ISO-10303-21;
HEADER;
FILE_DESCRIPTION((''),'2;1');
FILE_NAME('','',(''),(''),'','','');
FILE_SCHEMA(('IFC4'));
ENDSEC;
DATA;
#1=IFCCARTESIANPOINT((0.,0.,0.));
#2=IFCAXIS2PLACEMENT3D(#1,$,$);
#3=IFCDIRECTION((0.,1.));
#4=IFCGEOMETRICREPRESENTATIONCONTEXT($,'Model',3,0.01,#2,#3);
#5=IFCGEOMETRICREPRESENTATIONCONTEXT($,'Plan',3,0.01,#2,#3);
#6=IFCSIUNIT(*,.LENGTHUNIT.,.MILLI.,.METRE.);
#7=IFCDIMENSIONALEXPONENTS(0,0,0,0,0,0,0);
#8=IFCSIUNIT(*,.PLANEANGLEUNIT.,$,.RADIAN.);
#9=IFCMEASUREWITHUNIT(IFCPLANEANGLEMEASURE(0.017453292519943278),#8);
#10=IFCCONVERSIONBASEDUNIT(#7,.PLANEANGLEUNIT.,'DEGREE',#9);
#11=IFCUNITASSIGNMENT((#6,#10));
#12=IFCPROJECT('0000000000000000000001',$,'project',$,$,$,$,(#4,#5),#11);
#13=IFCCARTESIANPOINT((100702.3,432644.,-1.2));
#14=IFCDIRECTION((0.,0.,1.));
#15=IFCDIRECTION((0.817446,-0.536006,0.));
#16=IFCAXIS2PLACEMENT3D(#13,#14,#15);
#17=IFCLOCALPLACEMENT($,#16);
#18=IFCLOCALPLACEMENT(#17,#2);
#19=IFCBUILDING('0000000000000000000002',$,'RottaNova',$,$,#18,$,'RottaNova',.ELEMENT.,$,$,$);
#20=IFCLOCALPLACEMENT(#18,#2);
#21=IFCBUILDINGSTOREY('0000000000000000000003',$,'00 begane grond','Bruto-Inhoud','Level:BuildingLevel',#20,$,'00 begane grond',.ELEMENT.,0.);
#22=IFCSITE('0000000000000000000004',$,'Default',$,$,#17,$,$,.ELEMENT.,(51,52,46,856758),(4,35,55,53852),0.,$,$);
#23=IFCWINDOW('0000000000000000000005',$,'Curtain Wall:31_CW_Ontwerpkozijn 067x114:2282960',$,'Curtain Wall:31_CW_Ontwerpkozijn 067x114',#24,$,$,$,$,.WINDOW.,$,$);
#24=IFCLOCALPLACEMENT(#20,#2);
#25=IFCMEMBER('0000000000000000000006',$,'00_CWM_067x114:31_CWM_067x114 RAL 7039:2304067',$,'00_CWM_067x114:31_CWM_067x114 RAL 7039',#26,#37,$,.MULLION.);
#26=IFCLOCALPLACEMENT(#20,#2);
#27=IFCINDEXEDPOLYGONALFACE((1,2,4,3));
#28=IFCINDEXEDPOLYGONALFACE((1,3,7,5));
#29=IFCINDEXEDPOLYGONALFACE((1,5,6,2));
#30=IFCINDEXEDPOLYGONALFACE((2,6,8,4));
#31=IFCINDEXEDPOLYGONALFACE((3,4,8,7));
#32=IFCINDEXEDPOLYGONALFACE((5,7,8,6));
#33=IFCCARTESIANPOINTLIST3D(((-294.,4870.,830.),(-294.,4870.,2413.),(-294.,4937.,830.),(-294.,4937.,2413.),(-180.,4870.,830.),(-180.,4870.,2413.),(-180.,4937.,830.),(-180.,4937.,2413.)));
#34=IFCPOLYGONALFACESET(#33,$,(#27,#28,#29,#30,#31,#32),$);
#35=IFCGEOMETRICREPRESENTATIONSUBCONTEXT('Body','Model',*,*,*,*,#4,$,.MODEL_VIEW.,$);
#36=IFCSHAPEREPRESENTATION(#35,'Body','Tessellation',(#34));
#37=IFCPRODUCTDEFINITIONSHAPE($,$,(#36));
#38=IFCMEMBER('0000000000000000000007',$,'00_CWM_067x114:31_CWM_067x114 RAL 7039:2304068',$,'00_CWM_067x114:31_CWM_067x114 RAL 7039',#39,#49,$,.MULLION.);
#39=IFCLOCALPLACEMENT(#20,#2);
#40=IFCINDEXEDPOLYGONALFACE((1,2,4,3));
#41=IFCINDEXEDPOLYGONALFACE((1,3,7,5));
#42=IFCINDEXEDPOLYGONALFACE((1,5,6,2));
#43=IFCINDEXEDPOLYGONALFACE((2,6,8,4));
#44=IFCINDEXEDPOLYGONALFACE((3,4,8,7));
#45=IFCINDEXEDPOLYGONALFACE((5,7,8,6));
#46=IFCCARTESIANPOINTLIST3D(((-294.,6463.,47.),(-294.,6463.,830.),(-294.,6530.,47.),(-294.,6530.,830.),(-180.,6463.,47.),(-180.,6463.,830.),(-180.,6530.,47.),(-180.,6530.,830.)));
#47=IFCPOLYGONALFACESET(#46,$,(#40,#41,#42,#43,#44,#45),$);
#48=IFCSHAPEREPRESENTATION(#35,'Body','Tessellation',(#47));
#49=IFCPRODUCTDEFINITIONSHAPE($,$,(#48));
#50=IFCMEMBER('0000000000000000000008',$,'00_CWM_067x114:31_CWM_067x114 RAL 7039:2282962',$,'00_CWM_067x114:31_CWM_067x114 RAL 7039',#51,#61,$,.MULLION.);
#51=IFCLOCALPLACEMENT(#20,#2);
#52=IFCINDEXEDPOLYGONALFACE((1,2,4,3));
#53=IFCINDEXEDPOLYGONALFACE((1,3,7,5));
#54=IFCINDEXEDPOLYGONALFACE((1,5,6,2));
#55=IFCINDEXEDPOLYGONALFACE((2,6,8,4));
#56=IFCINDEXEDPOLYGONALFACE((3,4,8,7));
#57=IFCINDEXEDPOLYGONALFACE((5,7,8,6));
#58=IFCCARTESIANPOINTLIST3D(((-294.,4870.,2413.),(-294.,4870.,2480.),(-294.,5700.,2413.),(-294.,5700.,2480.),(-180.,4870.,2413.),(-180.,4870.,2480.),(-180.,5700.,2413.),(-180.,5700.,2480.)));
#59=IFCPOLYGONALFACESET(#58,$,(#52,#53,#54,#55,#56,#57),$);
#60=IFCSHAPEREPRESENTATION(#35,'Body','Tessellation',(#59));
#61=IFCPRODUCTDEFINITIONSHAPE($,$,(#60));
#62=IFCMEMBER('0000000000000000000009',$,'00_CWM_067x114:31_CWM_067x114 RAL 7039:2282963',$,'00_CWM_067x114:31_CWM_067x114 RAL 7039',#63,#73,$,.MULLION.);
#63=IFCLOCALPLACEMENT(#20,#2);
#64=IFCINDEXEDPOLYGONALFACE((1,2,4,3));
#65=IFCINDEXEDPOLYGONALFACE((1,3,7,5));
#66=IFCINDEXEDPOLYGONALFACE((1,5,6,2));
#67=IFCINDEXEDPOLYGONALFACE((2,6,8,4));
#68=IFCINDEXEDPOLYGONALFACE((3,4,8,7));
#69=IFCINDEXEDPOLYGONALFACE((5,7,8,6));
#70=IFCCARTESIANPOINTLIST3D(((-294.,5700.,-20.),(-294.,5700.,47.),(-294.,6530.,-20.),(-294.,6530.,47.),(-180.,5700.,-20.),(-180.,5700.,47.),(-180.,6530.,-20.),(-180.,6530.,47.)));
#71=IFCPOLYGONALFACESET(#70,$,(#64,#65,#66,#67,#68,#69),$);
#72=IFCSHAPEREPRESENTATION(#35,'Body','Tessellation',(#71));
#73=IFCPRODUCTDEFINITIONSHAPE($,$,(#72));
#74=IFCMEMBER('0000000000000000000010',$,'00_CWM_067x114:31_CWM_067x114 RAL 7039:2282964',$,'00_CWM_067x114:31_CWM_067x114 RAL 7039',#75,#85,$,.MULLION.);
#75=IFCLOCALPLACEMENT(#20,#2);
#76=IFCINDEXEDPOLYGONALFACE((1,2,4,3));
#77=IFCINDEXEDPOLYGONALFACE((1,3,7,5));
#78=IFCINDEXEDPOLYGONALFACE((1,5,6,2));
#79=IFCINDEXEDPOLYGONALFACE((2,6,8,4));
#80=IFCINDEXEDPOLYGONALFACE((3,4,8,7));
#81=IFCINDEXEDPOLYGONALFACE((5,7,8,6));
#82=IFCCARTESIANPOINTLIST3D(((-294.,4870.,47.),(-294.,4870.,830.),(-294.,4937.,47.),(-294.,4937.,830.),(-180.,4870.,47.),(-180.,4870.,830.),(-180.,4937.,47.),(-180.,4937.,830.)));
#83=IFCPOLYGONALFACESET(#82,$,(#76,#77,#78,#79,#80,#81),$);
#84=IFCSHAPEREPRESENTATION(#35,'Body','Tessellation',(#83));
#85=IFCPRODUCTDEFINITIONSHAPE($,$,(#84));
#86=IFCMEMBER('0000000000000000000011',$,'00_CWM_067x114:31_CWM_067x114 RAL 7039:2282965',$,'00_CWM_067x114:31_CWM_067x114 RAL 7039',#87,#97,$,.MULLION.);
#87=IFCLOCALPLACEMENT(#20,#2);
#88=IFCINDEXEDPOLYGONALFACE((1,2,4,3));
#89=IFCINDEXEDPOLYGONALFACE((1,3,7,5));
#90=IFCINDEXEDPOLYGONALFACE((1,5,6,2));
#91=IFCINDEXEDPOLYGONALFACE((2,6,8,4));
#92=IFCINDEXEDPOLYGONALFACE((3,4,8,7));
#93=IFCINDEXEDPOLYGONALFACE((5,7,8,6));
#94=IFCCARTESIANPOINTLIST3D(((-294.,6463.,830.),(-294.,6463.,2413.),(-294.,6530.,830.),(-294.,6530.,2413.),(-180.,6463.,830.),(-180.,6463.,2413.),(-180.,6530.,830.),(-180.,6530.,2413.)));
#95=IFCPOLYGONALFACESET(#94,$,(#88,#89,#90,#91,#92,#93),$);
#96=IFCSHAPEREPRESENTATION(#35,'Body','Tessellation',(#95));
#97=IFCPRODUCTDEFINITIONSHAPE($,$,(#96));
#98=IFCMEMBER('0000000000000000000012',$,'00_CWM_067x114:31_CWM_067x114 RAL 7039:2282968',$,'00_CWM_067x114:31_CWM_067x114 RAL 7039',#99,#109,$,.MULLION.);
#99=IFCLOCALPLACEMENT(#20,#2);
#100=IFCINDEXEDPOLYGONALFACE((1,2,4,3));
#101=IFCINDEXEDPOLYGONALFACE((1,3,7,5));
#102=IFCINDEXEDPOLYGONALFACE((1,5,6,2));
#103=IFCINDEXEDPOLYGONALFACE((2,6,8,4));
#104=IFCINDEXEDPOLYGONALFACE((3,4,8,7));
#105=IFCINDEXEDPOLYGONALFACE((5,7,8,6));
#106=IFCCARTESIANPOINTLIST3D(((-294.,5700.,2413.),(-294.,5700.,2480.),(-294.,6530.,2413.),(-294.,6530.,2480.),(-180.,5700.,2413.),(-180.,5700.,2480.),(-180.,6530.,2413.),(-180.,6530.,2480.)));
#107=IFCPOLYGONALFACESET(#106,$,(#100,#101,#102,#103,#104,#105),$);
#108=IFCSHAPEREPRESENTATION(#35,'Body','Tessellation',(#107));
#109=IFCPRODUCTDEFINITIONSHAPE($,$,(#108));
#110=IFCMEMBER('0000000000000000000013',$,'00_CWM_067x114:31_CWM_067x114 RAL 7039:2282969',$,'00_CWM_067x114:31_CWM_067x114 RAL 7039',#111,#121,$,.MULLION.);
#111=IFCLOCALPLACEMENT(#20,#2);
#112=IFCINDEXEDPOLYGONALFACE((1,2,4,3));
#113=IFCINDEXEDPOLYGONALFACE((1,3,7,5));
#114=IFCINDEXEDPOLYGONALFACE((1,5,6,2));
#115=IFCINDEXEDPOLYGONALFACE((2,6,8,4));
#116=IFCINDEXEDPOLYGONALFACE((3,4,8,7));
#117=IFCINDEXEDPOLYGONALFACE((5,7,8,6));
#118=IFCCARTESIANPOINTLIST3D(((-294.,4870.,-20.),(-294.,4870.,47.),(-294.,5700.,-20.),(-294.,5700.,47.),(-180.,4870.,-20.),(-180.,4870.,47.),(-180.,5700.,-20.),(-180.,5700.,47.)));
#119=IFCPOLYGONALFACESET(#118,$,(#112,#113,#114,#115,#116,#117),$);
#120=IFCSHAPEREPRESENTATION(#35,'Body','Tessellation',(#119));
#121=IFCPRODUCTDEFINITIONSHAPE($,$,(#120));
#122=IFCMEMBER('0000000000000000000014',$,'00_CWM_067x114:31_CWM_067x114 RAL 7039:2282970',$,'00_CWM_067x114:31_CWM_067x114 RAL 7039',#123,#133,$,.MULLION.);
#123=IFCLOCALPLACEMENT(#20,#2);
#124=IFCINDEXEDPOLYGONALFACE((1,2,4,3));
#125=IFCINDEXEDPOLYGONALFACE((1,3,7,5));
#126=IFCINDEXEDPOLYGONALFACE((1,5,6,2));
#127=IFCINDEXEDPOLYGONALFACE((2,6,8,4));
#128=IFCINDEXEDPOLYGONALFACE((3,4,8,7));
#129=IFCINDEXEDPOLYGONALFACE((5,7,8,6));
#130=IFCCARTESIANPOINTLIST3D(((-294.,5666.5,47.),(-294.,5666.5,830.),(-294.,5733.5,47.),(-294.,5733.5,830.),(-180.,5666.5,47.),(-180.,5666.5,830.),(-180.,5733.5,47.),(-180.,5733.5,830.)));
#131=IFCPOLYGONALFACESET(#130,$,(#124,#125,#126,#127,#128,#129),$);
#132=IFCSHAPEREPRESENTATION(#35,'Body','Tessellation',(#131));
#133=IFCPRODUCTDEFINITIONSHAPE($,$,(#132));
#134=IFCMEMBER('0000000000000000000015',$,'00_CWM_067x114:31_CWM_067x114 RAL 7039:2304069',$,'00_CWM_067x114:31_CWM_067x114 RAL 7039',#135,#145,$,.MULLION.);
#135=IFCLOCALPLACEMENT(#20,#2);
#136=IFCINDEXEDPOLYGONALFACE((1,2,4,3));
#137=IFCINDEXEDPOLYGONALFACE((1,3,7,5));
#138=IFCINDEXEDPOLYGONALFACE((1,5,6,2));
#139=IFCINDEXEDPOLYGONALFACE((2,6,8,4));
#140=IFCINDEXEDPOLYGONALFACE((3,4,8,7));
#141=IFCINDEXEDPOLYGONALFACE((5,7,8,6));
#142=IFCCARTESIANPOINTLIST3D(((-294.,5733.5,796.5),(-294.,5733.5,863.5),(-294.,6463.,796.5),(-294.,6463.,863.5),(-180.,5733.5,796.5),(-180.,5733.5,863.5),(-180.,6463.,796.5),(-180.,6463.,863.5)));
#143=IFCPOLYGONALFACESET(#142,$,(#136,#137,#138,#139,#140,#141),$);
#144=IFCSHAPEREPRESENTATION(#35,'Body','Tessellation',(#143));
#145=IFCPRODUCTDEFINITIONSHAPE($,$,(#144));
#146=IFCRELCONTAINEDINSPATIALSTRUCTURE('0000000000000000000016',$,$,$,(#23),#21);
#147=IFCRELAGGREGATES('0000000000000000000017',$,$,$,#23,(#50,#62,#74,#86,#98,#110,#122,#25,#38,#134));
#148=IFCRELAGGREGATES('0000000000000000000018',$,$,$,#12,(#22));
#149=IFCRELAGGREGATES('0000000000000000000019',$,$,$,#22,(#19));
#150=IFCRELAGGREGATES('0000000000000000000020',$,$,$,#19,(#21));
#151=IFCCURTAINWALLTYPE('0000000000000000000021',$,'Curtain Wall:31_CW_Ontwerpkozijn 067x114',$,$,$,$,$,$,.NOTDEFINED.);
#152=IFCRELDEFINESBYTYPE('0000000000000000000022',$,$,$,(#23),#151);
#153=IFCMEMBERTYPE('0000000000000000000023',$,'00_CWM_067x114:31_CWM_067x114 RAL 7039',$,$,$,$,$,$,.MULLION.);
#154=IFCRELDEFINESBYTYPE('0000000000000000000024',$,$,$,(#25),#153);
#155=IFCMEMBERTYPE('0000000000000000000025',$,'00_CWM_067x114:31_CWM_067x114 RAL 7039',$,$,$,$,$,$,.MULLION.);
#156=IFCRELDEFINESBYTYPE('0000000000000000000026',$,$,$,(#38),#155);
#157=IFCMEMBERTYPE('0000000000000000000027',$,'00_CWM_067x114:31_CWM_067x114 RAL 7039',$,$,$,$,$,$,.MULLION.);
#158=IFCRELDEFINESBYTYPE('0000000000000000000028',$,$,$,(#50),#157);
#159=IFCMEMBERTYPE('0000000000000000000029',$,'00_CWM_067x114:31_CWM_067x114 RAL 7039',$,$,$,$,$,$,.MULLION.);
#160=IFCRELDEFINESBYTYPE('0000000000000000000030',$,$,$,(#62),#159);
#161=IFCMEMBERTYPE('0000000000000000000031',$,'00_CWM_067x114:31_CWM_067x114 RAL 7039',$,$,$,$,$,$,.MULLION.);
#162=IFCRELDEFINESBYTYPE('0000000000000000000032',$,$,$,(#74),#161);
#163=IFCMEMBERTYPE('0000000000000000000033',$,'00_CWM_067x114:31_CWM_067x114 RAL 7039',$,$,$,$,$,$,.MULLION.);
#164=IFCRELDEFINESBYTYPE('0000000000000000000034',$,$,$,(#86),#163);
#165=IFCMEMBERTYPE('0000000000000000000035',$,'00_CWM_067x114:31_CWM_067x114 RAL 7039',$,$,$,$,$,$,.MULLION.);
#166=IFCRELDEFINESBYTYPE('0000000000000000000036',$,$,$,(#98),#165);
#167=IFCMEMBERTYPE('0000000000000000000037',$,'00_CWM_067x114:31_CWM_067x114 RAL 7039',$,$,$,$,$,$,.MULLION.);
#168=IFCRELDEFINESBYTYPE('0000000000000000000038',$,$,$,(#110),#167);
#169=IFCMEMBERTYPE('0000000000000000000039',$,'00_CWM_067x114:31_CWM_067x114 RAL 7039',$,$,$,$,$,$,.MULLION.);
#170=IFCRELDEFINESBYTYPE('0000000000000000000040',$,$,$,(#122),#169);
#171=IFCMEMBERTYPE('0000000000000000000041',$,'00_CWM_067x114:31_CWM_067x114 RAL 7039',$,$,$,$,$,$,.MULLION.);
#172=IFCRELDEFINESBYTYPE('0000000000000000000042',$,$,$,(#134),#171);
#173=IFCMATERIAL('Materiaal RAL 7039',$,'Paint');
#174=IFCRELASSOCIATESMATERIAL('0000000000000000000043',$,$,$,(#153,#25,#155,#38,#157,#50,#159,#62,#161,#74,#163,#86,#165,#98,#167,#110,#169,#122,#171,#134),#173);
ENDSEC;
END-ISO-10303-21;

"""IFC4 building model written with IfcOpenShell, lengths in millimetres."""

from ifc_helpers import new_model, entity, si_unit, converted_unit, direction, frame, origin, place, context, subcontext, project, spatial, indexed_curve, outline, extrude, source, transform, mapped, material, type_object, type_shapes, element, aggregate, save


model = new_model("IFC4")

# Units and contexts
model_context = context("Model", 3, precision=0.01, world=origin(), true_north=direction((0.0, 1.0)))
plan_context = context("Plan", 3, precision=0.01, world=origin(), true_north=direction((0.0, 1.0)))
body_context = subcontext(model_context, "Body", "Model", "MODEL_VIEW")
ifc_project = project(units=[si_unit("LENGTHUNIT", "METRE", prefix="MILLI"), converted_unit("PLANEANGLEUNIT", "DEGREE", entity("IfcPlaneAngleMeasure", 0.017453292519943278), si_unit("PLANEANGLEUNIT", "RADIAN"), dimensions=[0, 0, 0, 0, 0, 0, 0])], contexts=[model_context, plan_context])

# Site, building, storey
site_placement = place(None, frame((100702.3, 432644.0, -1.2), z_axis=(0.0, 0.0, 1.0), x_axis=(0.817446, -0.536006, 0.0)))
site = spatial("IfcSite", under=ifc_project, at=site_placement, Name="Default", CompositionType="ELEMENT", RefLatitude=(51, 52, 46, 856758), RefLongitude=(4, 35, 55, 53852), RefElevation=0.0)
building_placement = place(site_placement, origin())
building = spatial("IfcBuilding", under=site, at=building_placement, Name="RottaNova", LongName="RottaNova", CompositionType="ELEMENT")
storey_placement = place(building_placement, origin())
storey = spatial("IfcBuildingStorey", under=building, at=storey_placement, Name="00 begane grond", Description="Bruto-Inhoud", ObjectType="Level:BuildingLevel", LongName="00 begane grond", CompositionType="ELEMENT", Elevation=0.0)

# Window, members
curtain_wall_type = type_object("IfcCurtainWallType", Name="Curtain Wall:31_CW_Ontwerpkozijn 067x114", PredefinedType="NOTDEFINED")
window_placement = place(storey_placement, origin())
window = element("IfcWindow", 1, at=window_placement, inside=storey, type_object=curtain_wall_type, Name="Curtain Wall:31_CW_Ontwerpkozijn 067x114:2282960", ObjectType="Curtain Wall:31_CW_Ontwerpkozijn 067x114", PredefinedType="WINDOW")
ifc_material_1 = material(Name="Materiaal RAL 7039", Category="Paint")
member_type_1 = type_object("IfcMemberType", Name="00_CWM_067x114:31_CWM_067x114 RAL 7039", PredefinedType="MULLION", material=ifc_material_1)
shared_shape_1 = source(origin(), body_context, "Body", "SweptSolid", [
    extrude(outline(indexed_curve([(-33.5, -57.0), (33.5, -57.0), (33.5, 57.0), (-33.5, 57.0), (-33.5, -57.0)], self_intersect=False)), frame((-33.5, 57.0, -1583.0), z_axis=(0.0, 0.0, 1.0), x_axis=(-1.0, 0.0, 0.0)), (0.0, 0.0, 1.0), 1583.0),
])
type_shapes(member_type_1, [shared_shape_1])
member_1_placement = place(window_placement, frame((-180.0, 4870.0, 830.0), z_axis=(0.0, 0.0, -1.0), x_axis=(0.0, -1.0, 0.0)))
member_1 = element("IfcMember", 2, at=member_1_placement, type_object=member_type_1, material=ifc_material_1, Name="00_CWM_067x114:31_CWM_067x114 RAL 7039:2304067", ObjectType="00_CWM_067x114:31_CWM_067x114 RAL 7039", PredefinedType="MULLION", context=body_context, shape_type="MappedRepresentation", body=[
    mapped(shared_shape_1, transform((0.0, 0.0, 0.0), scale=1.0)),
])
member_type_2 = type_object("IfcMemberType", Name="00_CWM_067x114:31_CWM_067x114 RAL 7039", PredefinedType="MULLION", material=ifc_material_1)
shared_shape_2 = source(origin(), body_context, "Body", "SweptSolid", [
    extrude(outline(indexed_curve([(-33.5, -57.0), (33.5, -57.0), (33.5, 57.0), (-33.5, 57.0), (-33.5, -57.0)], self_intersect=False)), frame((-33.5, 57.0, -783.0), z_axis=(0.0, 0.0, 1.0), x_axis=(-1.0, 0.0, 0.0)), (0.0, 0.0, 1.0), 783.0),
])
type_shapes(member_type_2, [shared_shape_2])
member_2_placement = place(window_placement, frame((-180.0, 6530.0, 830.0), z_axis=(0.0, 0.0, 1.0), x_axis=(0.0, 1.0, 0.0)))
member_2 = element("IfcMember", 3, at=member_2_placement, type_object=member_type_2, material=ifc_material_1, Name="00_CWM_067x114:31_CWM_067x114 RAL 7039:2304068", ObjectType="00_CWM_067x114:31_CWM_067x114 RAL 7039", PredefinedType="MULLION", context=body_context, shape_type="MappedRepresentation", body=[
    mapped(shared_shape_2, transform((0.0, 0.0, 0.0), scale=1.0)),
])
member_type_3 = type_object("IfcMemberType", Name="00_CWM_067x114:31_CWM_067x114 RAL 7039", PredefinedType="MULLION", material=ifc_material_1)
shared_shape_3 = source(origin(), body_context, "Body", "SweptSolid", [
    extrude(outline(indexed_curve([(-33.5, -57.0), (33.5, -57.0), (33.5, 57.0), (-33.5, 57.0), (-33.5, -57.0)], self_intersect=False)), frame((-33.5, 57.0, -830.0), z_axis=(0.0, 0.0, 1.0), x_axis=(-1.0, 0.0, 0.0)), (0.0, 0.0, 1.0), 830.0),
])
type_shapes(member_type_3, [shared_shape_3])
member_3_placement = place(window_placement, frame((-180.0, 4870.0, 2480.0), z_axis=(0.0, -1.0, 0.0), x_axis=(0.0, 0.0, 1.0)))
member_3 = element("IfcMember", 4, at=member_3_placement, type_object=member_type_3, material=ifc_material_1, Name="00_CWM_067x114:31_CWM_067x114 RAL 7039:2282962", ObjectType="00_CWM_067x114:31_CWM_067x114 RAL 7039", PredefinedType="MULLION", context=body_context, shape_type="MappedRepresentation", body=[
    mapped(shared_shape_3, transform((0.0, 0.0, 0.0), scale=1.0)),
])
member_type_4 = type_object("IfcMemberType", Name="00_CWM_067x114:31_CWM_067x114 RAL 7039", PredefinedType="MULLION", material=ifc_material_1)
shared_shape_4 = source(origin(), body_context, "Body", "SweptSolid", [
    extrude(outline(indexed_curve([(-33.5, -57.0), (33.5, -57.0), (33.5, 57.0), (-33.5, 57.0), (-33.5, -57.0)], self_intersect=False)), frame((-33.5, 57.0, -830.0), z_axis=(0.0, 0.0, 1.0), x_axis=(-1.0, 0.0, 0.0)), (0.0, 0.0, 1.0), 830.0),
])
type_shapes(member_type_4, [shared_shape_4])
member_4_placement = place(window_placement, frame((-180.0, 6530.0, -20.0), z_axis=(0.0, 1.0, 0.0), x_axis=(0.0, 0.0, -1.0)))
member_4 = element("IfcMember", 5, at=member_4_placement, type_object=member_type_4, material=ifc_material_1, Name="00_CWM_067x114:31_CWM_067x114 RAL 7039:2282963", ObjectType="00_CWM_067x114:31_CWM_067x114 RAL 7039", PredefinedType="MULLION", context=body_context, shape_type="MappedRepresentation", body=[
    mapped(shared_shape_4, transform((0.0, 0.0, 0.0), scale=1.0)),
])
member_type_5 = type_object("IfcMemberType", Name="00_CWM_067x114:31_CWM_067x114 RAL 7039", PredefinedType="MULLION", material=ifc_material_1)
shared_shape_5 = source(origin(), body_context, "Body", "SweptSolid", [
    extrude(outline(indexed_curve([(-33.5, -57.0), (33.5, -57.0), (33.5, 57.0), (-33.5, 57.0), (-33.5, -57.0)], self_intersect=False)), frame((-33.5, 57.0, -783.0), z_axis=(0.0, 0.0, 1.0), x_axis=(-1.0, 0.0, 0.0)), (0.0, 0.0, 1.0), 783.0),
])
type_shapes(member_type_5, [shared_shape_5])
member_5_placement = place(window_placement, frame((-180.0, 4870.0, 47.0), z_axis=(0.0, 0.0, -1.0), x_axis=(0.0, -1.0, 0.0)))
member_5 = element("IfcMember", 6, at=member_5_placement, type_object=member_type_5, material=ifc_material_1, Name="00_CWM_067x114:31_CWM_067x114 RAL 7039:2282964", ObjectType="00_CWM_067x114:31_CWM_067x114 RAL 7039", PredefinedType="MULLION", context=body_context, shape_type="MappedRepresentation", body=[
    mapped(shared_shape_5, transform((0.0, 0.0, 0.0), scale=1.0)),
])
member_type_6 = type_object("IfcMemberType", Name="00_CWM_067x114:31_CWM_067x114 RAL 7039", PredefinedType="MULLION", material=ifc_material_1)
shared_shape_6 = source(origin(), body_context, "Body", "SweptSolid", [
    extrude(outline(indexed_curve([(-33.5, -57.0), (33.5, -57.0), (33.5, 57.0), (-33.5, 57.0), (-33.5, -57.0)], self_intersect=False)), frame((-33.5, 57.0, -1583.0), z_axis=(0.0, 0.0, 1.0), x_axis=(-1.0, 0.0, 0.0)), (0.0, 0.0, 1.0), 1583.0),
])
type_shapes(member_type_6, [shared_shape_6])
member_6_placement = place(window_placement, frame((-180.0, 6530.0, 2413.0), z_axis=(0.0, 0.0, 1.0), x_axis=(0.0, 1.0, 0.0)))
member_6 = element("IfcMember", 7, at=member_6_placement, type_object=member_type_6, material=ifc_material_1, Name="00_CWM_067x114:31_CWM_067x114 RAL 7039:2282965", ObjectType="00_CWM_067x114:31_CWM_067x114 RAL 7039", PredefinedType="MULLION", context=body_context, shape_type="MappedRepresentation", body=[
    mapped(shared_shape_6, transform((0.0, 0.0, 0.0), scale=1.0)),
])
member_type_7 = type_object("IfcMemberType", Name="00_CWM_067x114:31_CWM_067x114 RAL 7039", PredefinedType="MULLION", material=ifc_material_1)
shared_shape_7 = source(origin(), body_context, "Body", "SweptSolid", [
    extrude(outline(indexed_curve([(-33.5, -57.0), (33.5, -57.0), (33.5, 57.0), (-33.5, 57.0), (-33.5, -57.0)], self_intersect=False)), frame((-33.5, 57.0, -830.0), z_axis=(0.0, 0.0, 1.0), x_axis=(-1.0, 0.0, 0.0)), (0.0, 0.0, 1.0), 830.0),
])
type_shapes(member_type_7, [shared_shape_7])
member_7_placement = place(window_placement, frame((-180.0, 5700.0, 2480.0), z_axis=(0.0, -1.0, 0.0), x_axis=(0.0, 0.0, 1.0)))
member_7 = element("IfcMember", 8, at=member_7_placement, type_object=member_type_7, material=ifc_material_1, Name="00_CWM_067x114:31_CWM_067x114 RAL 7039:2282968", ObjectType="00_CWM_067x114:31_CWM_067x114 RAL 7039", PredefinedType="MULLION", context=body_context, shape_type="MappedRepresentation", body=[
    mapped(shared_shape_7, transform((0.0, 0.0, 0.0), scale=1.0)),
])
member_type_8 = type_object("IfcMemberType", Name="00_CWM_067x114:31_CWM_067x114 RAL 7039", PredefinedType="MULLION", material=ifc_material_1)
shared_shape_8 = source(origin(), body_context, "Body", "SweptSolid", [
    extrude(outline(indexed_curve([(-33.5, -57.0), (33.5, -57.0), (33.5, 57.0), (-33.5, 57.0), (-33.5, -57.0)], self_intersect=False)), frame((-33.5, 57.0, -830.0), z_axis=(0.0, 0.0, 1.0), x_axis=(-1.0, 0.0, 0.0)), (0.0, 0.0, 1.0), 830.0),
])
type_shapes(member_type_8, [shared_shape_8])
member_8_placement = place(window_placement, frame((-180.0, 5700.0, -20.0), z_axis=(0.0, 1.0, 0.0), x_axis=(0.0, 0.0, -1.0)))
member_8 = element("IfcMember", 9, at=member_8_placement, type_object=member_type_8, material=ifc_material_1, Name="00_CWM_067x114:31_CWM_067x114 RAL 7039:2282969", ObjectType="00_CWM_067x114:31_CWM_067x114 RAL 7039", PredefinedType="MULLION", context=body_context, shape_type="MappedRepresentation", body=[
    mapped(shared_shape_8, transform((0.0, 0.0, 0.0), scale=1.0)),
])
member_type_9 = type_object("IfcMemberType", Name="00_CWM_067x114:31_CWM_067x114 RAL 7039", PredefinedType="MULLION", material=ifc_material_1)
shared_shape_9 = source(origin(), body_context, "Body", "SweptSolid", [
    extrude(outline(indexed_curve([(-33.5, -57.0), (33.5, -57.0), (33.5, 57.0), (-33.5, 57.0), (-33.5, -57.0)], self_intersect=False)), frame((0.0, 57.0, -783.0), z_axis=(0.0, 0.0, 1.0), x_axis=(-1.0, 0.0, 0.0)), (0.0, 0.0, 1.0), 783.0),
])
type_shapes(member_type_9, [shared_shape_9])
member_9_placement = place(window_placement, frame((-180.0, 5700.0, 47.0), z_axis=(0.0, 0.0, -1.0), x_axis=(0.0, -1.0, 0.0)))
member_9 = element("IfcMember", 10, at=member_9_placement, type_object=member_type_9, material=ifc_material_1, Name="00_CWM_067x114:31_CWM_067x114 RAL 7039:2282970", ObjectType="00_CWM_067x114:31_CWM_067x114 RAL 7039", PredefinedType="MULLION", context=body_context, shape_type="MappedRepresentation", body=[
    mapped(shared_shape_9, transform((0.0, 0.0, 0.0), scale=1.0)),
])
member_type_10 = type_object("IfcMemberType", Name="00_CWM_067x114:31_CWM_067x114 RAL 7039", PredefinedType="MULLION", material=ifc_material_1)
shared_shape_10 = source(origin(), body_context, "Body", "SweptSolid", [
    extrude(outline(indexed_curve([(-33.5, -57.0), (33.5, -57.0), (33.5, 57.0), (-33.5, 57.0), (-33.5, -57.0)], self_intersect=False)), frame((0.0, 57.0, -729.5), z_axis=(0.0, 0.0, 1.0), x_axis=(-1.0, 0.0, 0.0)), (0.0, 0.0, 1.0), 729.5),
])
type_shapes(member_type_10, [shared_shape_10])
member_10_placement = place(window_placement, frame((-180.0, 5733.5, 830.0), z_axis=(0.0, -1.0, 0.0), x_axis=(0.0, 0.0, 1.0)))
member_10 = element("IfcMember", 11, at=member_10_placement, type_object=member_type_10, material=ifc_material_1, Name="00_CWM_067x114:31_CWM_067x114 RAL 7039:2304069", ObjectType="00_CWM_067x114:31_CWM_067x114 RAL 7039", PredefinedType="MULLION", context=body_context, shape_type="MappedRepresentation", body=[
    mapped(shared_shape_10, transform((0.0, 0.0, 0.0), scale=1.0)),
])
aggregate(window, [member_3, member_4, member_5, member_6, member_7, member_8, member_9, member_1, member_2, member_10])

save(model, "model.ifc")
